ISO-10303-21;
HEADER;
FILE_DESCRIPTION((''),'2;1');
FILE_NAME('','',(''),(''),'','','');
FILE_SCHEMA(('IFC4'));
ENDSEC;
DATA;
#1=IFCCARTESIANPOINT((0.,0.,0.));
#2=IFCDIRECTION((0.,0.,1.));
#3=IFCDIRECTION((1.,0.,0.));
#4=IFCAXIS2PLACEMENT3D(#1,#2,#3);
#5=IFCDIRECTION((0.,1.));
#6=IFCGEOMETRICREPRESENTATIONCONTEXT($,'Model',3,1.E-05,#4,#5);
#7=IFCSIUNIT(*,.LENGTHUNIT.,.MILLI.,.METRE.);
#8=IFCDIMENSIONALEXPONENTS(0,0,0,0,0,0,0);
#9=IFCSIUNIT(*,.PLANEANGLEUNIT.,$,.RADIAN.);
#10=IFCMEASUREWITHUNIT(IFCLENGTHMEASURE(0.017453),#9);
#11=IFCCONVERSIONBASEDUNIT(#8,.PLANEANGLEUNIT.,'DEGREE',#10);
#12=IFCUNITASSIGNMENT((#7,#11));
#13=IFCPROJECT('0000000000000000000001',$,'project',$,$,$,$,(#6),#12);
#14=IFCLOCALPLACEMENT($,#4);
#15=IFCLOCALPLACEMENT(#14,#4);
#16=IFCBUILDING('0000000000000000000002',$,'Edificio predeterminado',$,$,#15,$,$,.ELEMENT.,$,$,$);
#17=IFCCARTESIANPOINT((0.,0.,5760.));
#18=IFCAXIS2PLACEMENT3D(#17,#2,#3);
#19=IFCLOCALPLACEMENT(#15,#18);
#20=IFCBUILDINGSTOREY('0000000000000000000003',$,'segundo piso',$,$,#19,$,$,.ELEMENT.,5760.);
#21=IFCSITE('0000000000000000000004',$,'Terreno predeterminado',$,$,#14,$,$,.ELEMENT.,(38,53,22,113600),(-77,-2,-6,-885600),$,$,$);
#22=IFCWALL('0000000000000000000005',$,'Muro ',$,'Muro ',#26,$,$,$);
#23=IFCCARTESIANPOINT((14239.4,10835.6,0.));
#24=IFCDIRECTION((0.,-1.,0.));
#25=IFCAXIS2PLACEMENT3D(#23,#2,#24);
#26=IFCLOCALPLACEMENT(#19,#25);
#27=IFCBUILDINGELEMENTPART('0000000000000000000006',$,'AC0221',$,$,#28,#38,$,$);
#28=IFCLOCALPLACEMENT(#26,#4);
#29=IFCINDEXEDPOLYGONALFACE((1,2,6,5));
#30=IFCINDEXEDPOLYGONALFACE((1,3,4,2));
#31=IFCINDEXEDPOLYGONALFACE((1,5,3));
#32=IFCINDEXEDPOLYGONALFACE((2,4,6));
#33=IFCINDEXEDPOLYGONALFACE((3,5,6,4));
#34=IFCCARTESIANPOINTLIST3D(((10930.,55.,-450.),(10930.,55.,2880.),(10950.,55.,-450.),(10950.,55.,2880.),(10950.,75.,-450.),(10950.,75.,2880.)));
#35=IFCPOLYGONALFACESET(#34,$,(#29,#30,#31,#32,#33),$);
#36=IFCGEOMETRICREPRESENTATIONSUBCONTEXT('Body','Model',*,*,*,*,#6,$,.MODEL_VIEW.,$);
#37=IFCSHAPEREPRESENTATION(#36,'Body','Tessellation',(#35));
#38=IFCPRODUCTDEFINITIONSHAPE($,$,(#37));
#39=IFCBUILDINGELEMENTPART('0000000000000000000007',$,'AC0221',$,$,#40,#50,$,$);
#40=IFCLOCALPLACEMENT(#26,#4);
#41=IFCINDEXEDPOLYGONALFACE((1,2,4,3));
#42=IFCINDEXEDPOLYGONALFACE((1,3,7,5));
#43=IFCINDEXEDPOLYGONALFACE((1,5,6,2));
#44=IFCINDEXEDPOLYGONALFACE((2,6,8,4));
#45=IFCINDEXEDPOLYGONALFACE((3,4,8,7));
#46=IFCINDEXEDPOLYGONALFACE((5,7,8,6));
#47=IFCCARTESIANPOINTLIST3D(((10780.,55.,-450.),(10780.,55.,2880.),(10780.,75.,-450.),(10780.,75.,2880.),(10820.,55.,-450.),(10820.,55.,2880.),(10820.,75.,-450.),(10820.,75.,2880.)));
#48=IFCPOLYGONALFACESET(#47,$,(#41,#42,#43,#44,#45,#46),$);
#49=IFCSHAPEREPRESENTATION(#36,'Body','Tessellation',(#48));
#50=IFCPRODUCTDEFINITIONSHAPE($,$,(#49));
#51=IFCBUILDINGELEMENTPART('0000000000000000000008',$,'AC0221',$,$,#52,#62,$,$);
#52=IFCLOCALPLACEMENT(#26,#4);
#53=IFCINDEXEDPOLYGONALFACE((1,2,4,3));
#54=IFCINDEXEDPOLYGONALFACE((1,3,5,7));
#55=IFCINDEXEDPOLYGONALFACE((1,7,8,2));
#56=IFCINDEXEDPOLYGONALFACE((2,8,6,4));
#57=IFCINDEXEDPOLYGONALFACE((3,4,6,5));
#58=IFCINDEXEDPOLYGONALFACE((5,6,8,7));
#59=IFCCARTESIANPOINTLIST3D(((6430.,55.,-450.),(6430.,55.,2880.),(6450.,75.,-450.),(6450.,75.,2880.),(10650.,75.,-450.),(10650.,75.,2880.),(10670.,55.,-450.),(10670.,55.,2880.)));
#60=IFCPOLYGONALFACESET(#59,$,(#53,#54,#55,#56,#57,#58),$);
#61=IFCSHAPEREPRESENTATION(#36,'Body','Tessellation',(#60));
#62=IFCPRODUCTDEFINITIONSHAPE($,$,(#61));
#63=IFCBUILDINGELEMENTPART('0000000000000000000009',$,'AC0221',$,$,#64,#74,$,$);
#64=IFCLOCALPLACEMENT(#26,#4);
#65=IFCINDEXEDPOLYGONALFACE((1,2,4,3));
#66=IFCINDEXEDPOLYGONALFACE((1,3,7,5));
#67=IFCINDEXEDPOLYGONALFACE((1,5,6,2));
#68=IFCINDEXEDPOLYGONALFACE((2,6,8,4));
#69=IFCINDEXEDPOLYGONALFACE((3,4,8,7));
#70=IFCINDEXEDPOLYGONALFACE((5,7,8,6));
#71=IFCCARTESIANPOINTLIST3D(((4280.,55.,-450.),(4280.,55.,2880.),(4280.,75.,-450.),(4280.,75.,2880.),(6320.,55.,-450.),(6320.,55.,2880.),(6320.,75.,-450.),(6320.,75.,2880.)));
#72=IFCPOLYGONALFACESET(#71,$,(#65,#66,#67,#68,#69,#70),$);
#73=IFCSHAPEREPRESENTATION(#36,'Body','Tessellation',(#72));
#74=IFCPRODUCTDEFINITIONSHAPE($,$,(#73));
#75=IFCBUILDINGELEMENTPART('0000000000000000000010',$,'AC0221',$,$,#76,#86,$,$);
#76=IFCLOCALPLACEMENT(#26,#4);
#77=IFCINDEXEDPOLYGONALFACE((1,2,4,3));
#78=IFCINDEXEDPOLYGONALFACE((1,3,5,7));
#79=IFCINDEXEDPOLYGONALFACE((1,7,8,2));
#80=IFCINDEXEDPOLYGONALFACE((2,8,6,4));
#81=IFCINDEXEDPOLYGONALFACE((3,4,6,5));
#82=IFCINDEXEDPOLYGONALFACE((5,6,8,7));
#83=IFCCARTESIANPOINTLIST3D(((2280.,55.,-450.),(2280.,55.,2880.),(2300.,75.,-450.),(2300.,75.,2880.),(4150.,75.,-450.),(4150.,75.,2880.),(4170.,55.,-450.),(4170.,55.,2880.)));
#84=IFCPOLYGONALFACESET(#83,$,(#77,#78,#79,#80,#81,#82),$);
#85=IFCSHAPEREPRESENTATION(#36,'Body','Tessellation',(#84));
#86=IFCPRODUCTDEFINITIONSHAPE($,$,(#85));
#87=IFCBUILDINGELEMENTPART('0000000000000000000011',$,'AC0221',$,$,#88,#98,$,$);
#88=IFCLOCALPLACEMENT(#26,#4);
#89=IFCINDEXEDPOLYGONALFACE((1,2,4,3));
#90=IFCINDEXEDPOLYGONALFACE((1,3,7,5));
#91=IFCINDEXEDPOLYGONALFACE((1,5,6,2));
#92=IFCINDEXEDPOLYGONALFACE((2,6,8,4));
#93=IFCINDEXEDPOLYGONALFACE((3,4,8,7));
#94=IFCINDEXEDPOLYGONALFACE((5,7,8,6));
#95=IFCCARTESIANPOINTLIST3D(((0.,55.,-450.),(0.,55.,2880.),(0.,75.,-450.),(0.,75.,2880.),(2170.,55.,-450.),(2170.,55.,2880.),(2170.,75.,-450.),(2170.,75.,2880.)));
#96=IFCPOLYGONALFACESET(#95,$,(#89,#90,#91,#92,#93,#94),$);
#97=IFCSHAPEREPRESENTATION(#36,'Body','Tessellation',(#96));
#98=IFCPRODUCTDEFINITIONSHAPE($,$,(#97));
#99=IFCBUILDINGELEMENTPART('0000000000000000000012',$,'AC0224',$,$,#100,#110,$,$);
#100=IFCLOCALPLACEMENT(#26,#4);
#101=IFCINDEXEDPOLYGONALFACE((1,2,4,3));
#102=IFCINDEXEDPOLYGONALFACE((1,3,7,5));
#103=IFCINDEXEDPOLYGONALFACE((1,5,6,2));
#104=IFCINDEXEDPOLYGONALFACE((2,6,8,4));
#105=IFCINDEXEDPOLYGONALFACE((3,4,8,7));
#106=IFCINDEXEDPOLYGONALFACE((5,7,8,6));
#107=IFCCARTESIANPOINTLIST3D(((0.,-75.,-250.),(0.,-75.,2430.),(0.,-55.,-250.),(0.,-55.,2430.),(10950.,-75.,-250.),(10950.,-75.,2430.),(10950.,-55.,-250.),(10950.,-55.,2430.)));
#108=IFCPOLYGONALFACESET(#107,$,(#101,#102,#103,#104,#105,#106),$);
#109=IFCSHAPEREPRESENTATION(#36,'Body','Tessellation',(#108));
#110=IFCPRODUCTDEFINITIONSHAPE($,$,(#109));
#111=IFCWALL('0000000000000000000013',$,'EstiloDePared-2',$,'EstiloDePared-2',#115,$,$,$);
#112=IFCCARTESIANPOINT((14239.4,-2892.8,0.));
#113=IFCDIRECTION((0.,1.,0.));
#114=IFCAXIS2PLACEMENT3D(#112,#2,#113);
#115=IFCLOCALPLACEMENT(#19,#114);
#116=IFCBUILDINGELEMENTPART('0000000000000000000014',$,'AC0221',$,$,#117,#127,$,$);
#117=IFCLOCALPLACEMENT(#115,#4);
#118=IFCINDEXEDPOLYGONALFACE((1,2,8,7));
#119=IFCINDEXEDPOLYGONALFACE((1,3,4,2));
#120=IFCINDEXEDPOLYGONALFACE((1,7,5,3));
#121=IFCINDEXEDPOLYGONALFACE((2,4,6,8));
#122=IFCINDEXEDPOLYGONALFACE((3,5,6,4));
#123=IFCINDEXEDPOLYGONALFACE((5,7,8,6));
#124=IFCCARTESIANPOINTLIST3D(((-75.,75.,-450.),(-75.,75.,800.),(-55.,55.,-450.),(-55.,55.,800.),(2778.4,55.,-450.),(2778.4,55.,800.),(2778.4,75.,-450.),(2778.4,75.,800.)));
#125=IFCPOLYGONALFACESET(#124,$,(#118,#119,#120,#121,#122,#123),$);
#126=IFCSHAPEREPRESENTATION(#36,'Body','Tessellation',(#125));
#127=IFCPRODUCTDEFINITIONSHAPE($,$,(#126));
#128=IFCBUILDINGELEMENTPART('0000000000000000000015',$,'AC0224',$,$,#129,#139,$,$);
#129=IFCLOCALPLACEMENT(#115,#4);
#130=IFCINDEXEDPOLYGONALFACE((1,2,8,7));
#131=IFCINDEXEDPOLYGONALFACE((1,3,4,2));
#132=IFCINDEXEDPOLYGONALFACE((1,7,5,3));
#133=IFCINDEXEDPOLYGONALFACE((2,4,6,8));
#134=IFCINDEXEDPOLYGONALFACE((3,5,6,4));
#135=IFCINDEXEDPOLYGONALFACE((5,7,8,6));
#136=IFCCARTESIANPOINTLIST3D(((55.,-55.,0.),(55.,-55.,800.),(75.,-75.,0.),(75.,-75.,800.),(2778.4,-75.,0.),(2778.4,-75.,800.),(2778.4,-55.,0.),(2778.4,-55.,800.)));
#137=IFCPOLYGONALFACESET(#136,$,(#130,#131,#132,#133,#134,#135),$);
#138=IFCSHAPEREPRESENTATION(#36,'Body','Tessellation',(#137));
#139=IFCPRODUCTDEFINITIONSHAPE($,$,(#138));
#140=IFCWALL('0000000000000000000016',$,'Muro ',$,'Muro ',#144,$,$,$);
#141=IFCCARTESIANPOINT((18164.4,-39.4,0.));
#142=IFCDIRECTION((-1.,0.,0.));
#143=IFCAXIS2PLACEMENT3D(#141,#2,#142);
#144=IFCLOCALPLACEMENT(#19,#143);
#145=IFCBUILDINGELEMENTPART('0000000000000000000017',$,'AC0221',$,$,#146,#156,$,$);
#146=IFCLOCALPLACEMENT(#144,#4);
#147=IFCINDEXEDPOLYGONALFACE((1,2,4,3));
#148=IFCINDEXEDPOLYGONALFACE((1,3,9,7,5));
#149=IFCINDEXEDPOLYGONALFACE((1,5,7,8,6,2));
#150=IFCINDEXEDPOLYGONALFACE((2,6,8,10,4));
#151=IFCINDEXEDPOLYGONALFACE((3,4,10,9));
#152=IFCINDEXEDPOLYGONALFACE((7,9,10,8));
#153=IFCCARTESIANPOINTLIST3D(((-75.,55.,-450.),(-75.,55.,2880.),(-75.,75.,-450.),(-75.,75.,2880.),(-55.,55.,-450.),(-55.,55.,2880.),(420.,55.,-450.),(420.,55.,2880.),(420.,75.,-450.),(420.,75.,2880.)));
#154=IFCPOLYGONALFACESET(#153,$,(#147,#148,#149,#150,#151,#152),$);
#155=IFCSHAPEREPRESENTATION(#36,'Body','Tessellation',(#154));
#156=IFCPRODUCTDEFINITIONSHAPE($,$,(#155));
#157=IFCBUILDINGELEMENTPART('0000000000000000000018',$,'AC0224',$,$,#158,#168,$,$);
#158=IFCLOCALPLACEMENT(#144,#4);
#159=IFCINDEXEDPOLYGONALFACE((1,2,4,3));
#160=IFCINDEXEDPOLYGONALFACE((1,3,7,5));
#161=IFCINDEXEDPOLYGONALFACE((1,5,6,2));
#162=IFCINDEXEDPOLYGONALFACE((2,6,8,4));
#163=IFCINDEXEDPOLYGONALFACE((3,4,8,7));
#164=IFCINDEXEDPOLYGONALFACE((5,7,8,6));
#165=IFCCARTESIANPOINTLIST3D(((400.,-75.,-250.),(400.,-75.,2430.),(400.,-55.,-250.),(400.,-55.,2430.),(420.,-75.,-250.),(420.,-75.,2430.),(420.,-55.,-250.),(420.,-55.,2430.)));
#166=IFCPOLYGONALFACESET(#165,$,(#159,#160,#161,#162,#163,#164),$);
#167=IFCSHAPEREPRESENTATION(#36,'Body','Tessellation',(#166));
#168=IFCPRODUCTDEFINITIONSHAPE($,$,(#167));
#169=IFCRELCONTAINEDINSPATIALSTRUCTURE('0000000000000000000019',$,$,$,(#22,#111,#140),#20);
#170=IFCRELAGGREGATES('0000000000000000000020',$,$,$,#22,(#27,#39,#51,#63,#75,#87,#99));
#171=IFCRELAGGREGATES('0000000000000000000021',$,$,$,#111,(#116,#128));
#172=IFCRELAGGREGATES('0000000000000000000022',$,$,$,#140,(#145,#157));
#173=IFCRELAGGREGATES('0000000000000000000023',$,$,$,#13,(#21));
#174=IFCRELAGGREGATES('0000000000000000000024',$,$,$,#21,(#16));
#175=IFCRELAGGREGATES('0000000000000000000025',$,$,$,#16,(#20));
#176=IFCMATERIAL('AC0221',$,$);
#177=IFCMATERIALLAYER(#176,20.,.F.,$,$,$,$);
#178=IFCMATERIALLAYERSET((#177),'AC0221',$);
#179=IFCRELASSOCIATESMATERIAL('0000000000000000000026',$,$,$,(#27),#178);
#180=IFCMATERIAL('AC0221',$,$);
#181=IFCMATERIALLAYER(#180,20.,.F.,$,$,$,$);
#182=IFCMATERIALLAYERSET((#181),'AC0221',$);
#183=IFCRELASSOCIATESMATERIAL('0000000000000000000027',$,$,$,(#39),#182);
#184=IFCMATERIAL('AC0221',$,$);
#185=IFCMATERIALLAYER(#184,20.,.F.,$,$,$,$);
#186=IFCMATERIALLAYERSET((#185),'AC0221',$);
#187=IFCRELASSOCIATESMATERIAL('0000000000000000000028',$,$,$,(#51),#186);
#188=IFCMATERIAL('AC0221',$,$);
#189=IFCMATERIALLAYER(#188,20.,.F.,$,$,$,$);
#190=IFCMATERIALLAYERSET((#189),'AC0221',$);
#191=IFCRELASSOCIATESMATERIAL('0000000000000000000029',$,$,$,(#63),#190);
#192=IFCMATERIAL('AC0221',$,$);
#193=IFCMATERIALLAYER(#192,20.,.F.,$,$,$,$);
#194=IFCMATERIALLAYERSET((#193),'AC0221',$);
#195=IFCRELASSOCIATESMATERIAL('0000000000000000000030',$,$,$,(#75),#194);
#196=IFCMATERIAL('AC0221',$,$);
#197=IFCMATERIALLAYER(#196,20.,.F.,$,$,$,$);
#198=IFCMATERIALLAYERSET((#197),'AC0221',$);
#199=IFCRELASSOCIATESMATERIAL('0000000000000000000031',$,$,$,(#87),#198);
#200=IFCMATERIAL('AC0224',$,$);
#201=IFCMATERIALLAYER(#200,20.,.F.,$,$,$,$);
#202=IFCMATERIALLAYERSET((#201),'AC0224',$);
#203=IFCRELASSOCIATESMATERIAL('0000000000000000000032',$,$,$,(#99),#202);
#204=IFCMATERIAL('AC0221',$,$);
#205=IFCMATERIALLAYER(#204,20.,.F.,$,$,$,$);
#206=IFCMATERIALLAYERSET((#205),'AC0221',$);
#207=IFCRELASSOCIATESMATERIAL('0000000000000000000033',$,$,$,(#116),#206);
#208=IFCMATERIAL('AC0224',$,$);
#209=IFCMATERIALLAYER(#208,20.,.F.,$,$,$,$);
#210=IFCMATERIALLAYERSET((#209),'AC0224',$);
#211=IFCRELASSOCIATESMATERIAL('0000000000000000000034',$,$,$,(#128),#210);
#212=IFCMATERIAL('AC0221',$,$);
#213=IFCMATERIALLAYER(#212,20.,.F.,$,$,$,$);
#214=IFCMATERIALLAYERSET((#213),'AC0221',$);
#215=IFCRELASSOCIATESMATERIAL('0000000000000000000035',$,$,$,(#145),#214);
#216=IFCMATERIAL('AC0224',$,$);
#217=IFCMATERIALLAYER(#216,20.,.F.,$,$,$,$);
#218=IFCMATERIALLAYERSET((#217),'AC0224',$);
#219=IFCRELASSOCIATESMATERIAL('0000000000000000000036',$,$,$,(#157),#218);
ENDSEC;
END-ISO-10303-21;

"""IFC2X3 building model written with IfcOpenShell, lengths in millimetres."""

from ifc_helpers import new_model, entity, si_unit, converted_unit, direction, frame, origin_with_axes, place, context, subcontext, project, spatial, polyline, outline, extrude, material, layer, layer_set, layer_usage, element, aggregate, save


model = new_model("IFC2X3")

# Units and contexts
model_context = context("Model", 3, precision=1e-05, world=origin_with_axes(), true_north=direction((0.0, 1.0)))
body_context = subcontext(model_context, "Body", "Model", "MODEL_VIEW")
ifc_project = project(units=[si_unit("LENGTHUNIT", "METRE", prefix="MILLI"), converted_unit("PLANEANGLEUNIT", "DEGREE", entity("IfcLengthMeasure", 0.017453), si_unit("PLANEANGLEUNIT", "RADIAN"), dimensions=[0, 0, 0, 0, 0, 0, 0])], contexts=[model_context])

# Site, building, storey
site_placement = place(None, origin_with_axes())
site = spatial("IfcSite", under=ifc_project, at=site_placement, Name="Terreno predeterminado", CompositionType="ELEMENT", RefLatitude=(38, 53, 22, 113600), RefLongitude=(-77, -2, -6, -885600))
building_placement = place(site_placement, origin_with_axes())
building = spatial("IfcBuilding", under=site, at=building_placement, Name="Edificio predeterminado", CompositionType="ELEMENT")
storey_placement = place(building_placement, frame((0.0, 0.0, 5760.0), z_axis=(0.0, 0.0, 1.0), x_axis=(1.0, 0.0, 0.0)))
storey = spatial("IfcBuildingStorey", under=building, at=storey_placement, Name="segundo piso", CompositionType="ELEMENT", Elevation=5760.0)

# Walls, building element parts
wall_1_placement = place(storey_placement, frame((14239.4, 10835.6, 0.0), z_axis=(0.0, 0.0, 1.0), x_axis=(0.0, -1.0, 0.0)))
wall_1 = element("IfcWall", 1, at=wall_1_placement, inside=storey, Name="Muro ", ObjectType="Muro ")
ifc_material_1 = material(Name="AC0221")
ifc_layer_1 = layer(ifc_material_1, 20.0, ventilated=False)
ifc_layer_set_1 = layer_set([ifc_layer_1], Name="AC0221")
ifc_layer_usage_1 = layer_usage(ifc_layer_set_1, "AXIS2", "NEGATIVE", -75.0)
building_element_part_1_placement = place(wall_1_placement, origin_with_axes())
building_element_part_1 = element("IfcBuildingElementPart", 2, at=building_element_part_1_placement, material=ifc_layer_usage_1, Name="AC0221", context=body_context, shape_type="SweptSolid", body=[
    extrude(outline(polyline([(10950.0, 75.0), (10950.0, 55.0), (10930.0, 55.0), (10950.0, 75.0)])), frame((0.0, 0.0, -450.0), z_axis=(0.0, 0.0, 1.0), x_axis=(1.0, 0.0, 0.0)), (0.0, 0.0, 1.0), 3330.0),
])
ifc_material_2 = material(Name="AC0221")
ifc_layer_2 = layer(ifc_material_2, 20.0, ventilated=False)
ifc_layer_set_2 = layer_set([ifc_layer_2], Name="AC0221")
ifc_layer_usage_2 = layer_usage(ifc_layer_set_2, "AXIS2", "NEGATIVE", -75.0)
building_element_part_2_placement = place(wall_1_placement, origin_with_axes())
building_element_part_2 = element("IfcBuildingElementPart", 3, at=building_element_part_2_placement, material=ifc_layer_usage_2, Name="AC0221", context=body_context, shape_type="SweptSolid", body=[
    extrude(outline(polyline([(10820.0, 75.0), (10820.0, 55.0), (10780.0, 55.0), (10780.0, 75.0), (10820.0, 75.0)])), frame((0.0, 0.0, -450.0), z_axis=(0.0, 0.0, 1.0), x_axis=(1.0, 0.0, 0.0)), (0.0, 0.0, 1.0), 3330.0),
])
ifc_material_3 = material(Name="AC0221")
ifc_layer_3 = layer(ifc_material_3, 20.0, ventilated=False)
ifc_layer_set_3 = layer_set([ifc_layer_3], Name="AC0221")
ifc_layer_usage_3 = layer_usage(ifc_layer_set_3, "AXIS2", "NEGATIVE", -75.0)
building_element_part_3_placement = place(wall_1_placement, origin_with_axes())
building_element_part_3 = element("IfcBuildingElementPart", 4, at=building_element_part_3_placement, material=ifc_layer_usage_3, Name="AC0221", context=body_context, shape_type="SweptSolid", body=[
    extrude(outline(polyline([(10650.0, 75.0), (10670.0, 55.0), (6430.0, 55.0), (6450.0, 75.0), (10650.0, 75.0)])), frame((0.0, 0.0, -450.0), z_axis=(0.0, 0.0, 1.0), x_axis=(1.0, 0.0, 0.0)), (0.0, 0.0, 1.0), 3330.0),
])
ifc_material_4 = material(Name="AC0221")
ifc_layer_4 = layer(ifc_material_4, 20.0, ventilated=False)
ifc_layer_set_4 = layer_set([ifc_layer_4], Name="AC0221")
ifc_layer_usage_4 = layer_usage(ifc_layer_set_4, "AXIS2", "NEGATIVE", -75.0)
building_element_part_4_placement = place(wall_1_placement, origin_with_axes())
building_element_part_4 = element("IfcBuildingElementPart", 5, at=building_element_part_4_placement, material=ifc_layer_usage_4, Name="AC0221", context=body_context, shape_type="SweptSolid", body=[
    extrude(outline(polyline([(4280.0, 75.0), (6320.0, 75.0), (6320.0, 55.0), (4280.0, 55.0), (4280.0, 75.0)])), frame((0.0, 0.0, -450.0), z_axis=(0.0, 0.0, 1.0), x_axis=(1.0, 0.0, 0.0)), (0.0, 0.0, 1.0), 3330.0),
])
ifc_material_5 = material(Name="AC0221")
ifc_layer_5 = layer(ifc_material_5, 20.0, ventilated=False)
ifc_layer_set_5 = layer_set([ifc_layer_5], Name="AC0221")
ifc_layer_usage_5 = layer_usage(ifc_layer_set_5, "AXIS2", "NEGATIVE", -75.0)
building_element_part_5_placement = place(wall_1_placement, origin_with_axes())
building_element_part_5 = element("IfcBuildingElementPart", 6, at=building_element_part_5_placement, material=ifc_layer_usage_5, Name="AC0221", context=body_context, shape_type="SweptSolid", body=[
    extrude(outline(polyline([(4150.0, 75.0), (4170.0, 55.0), (2280.0, 55.0), (2300.0, 75.0), (4150.0, 75.0)])), frame((0.0, 0.0, -450.0), z_axis=(0.0, 0.0, 1.0), x_axis=(1.0, 0.0, 0.0)), (0.0, 0.0, 1.0), 3330.0),
])
ifc_material_6 = material(Name="AC0221")
ifc_layer_6 = layer(ifc_material_6, 20.0, ventilated=False)
ifc_layer_set_6 = layer_set([ifc_layer_6], Name="AC0221")
ifc_layer_usage_6 = layer_usage(ifc_layer_set_6, "AXIS2", "NEGATIVE", -75.0)
building_element_part_6_placement = place(wall_1_placement, origin_with_axes())
building_element_part_6 = element("IfcBuildingElementPart", 7, at=building_element_part_6_placement, material=ifc_layer_usage_6, Name="AC0221", context=body_context, shape_type="SweptSolid", body=[
    extrude(outline(polyline([(2170.0, 75.0), (2170.0, 55.0), (0.0, 55.0), (0.0, 75.0), (2170.0, 75.0)])), frame((0.0, 0.0, -450.0), z_axis=(0.0, 0.0, 1.0), x_axis=(1.0, 0.0, 0.0)), (0.0, 0.0, 1.0), 3330.0),
])
ifc_material_7 = material(Name="AC0224")
ifc_layer_7 = layer(ifc_material_7, 20.0, ventilated=False)
ifc_layer_set_7 = layer_set([ifc_layer_7], Name="AC0224")
ifc_layer_usage_7 = layer_usage(ifc_layer_set_7, "AXIS2", "NEGATIVE", 55.0)
building_element_part_7_placement = place(wall_1_placement, origin_with_axes())
building_element_part_7 = element("IfcBuildingElementPart", 8, at=building_element_part_7_placement, material=ifc_layer_usage_7, Name="AC0224", context=body_context, shape_type="SweptSolid", body=[
    extrude(outline(polyline([(10950.0, -55.0), (10950.0, -75.0), (0.0, -75.0), (0.0, -55.0), (10950.0, -55.0)])), frame((0.0, 0.0, -250.0), z_axis=(0.0, 0.0, 1.0), x_axis=(1.0, 0.0, 0.0)), (0.0, 0.0, 1.0), 2680.0),
])
aggregate(wall_1, [building_element_part_1, building_element_part_2, building_element_part_3, building_element_part_4, building_element_part_5, building_element_part_6, building_element_part_7])
wall_2_placement = place(storey_placement, frame((14239.4, -2892.8, 0.0), z_axis=(0.0, 0.0, 1.0), x_axis=(0.0, 1.0, 0.0)))
wall_2 = element("IfcWall", 9, at=wall_2_placement, inside=storey, Name="EstiloDePared-2", ObjectType="EstiloDePared-2")
ifc_material_8 = material(Name="AC0221")
ifc_layer_8 = layer(ifc_material_8, 20.0, ventilated=False)
ifc_layer_set_8 = layer_set([ifc_layer_8], Name="AC0221")
ifc_layer_usage_8 = layer_usage(ifc_layer_set_8, "AXIS2", "NEGATIVE", -75.0)
building_element_part_8_placement = place(wall_2_placement, origin_with_axes())
building_element_part_8 = element("IfcBuildingElementPart", 10, at=building_element_part_8_placement, material=ifc_layer_usage_8, Name="AC0221", context=body_context, shape_type="SweptSolid", body=[
    extrude(outline(polyline([(2778.4, 75.0), (2778.4, 55.0), (-55.0, 55.0), (-75.0, 75.0), (2778.4, 75.0)])), frame((0.0, 0.0, -450.0), z_axis=(0.0, 0.0, 1.0), x_axis=(1.0, 0.0, 0.0)), (0.0, 0.0, 1.0), 1250.0),
])
ifc_material_9 = material(Name="AC0224")
ifc_layer_9 = layer(ifc_material_9, 20.0, ventilated=False)
ifc_layer_set_9 = layer_set([ifc_layer_9], Name="AC0224")
ifc_layer_usage_9 = layer_usage(ifc_layer_set_9, "AXIS2", "NEGATIVE", 55.0)
building_element_part_9_placement = place(wall_2_placement, origin_with_axes())
building_element_part_9 = element("IfcBuildingElementPart", 11, at=building_element_part_9_placement, material=ifc_layer_usage_9, Name="AC0224", context=body_context, shape_type="SweptSolid", body=[
    extrude(outline(polyline([(2778.4, -55.0), (2778.4, -75.0), (75.0, -75.0), (55.0, -55.0), (2778.4, -55.0)])), origin_with_axes(), (0.0, 0.0, 1.0), 800.0),
])
aggregate(wall_2, [building_element_part_8, building_element_part_9])
wall_3_placement = place(storey_placement, frame((18164.4, -39.4, 0.0), z_axis=(0.0, 0.0, 1.0), x_axis=(-1.0, 0.0, 0.0)))
wall_3 = element("IfcWall", 12, at=wall_3_placement, inside=storey, Name="Muro ", ObjectType="Muro ")
ifc_material_10 = material(Name="AC0221")
ifc_layer_10 = layer(ifc_material_10, 20.0, ventilated=False)
ifc_layer_set_10 = layer_set([ifc_layer_10], Name="AC0221")
ifc_layer_usage_10 = layer_usage(ifc_layer_set_10, "AXIS2", "NEGATIVE", -75.0)
building_element_part_10_placement = place(wall_3_placement, origin_with_axes())
building_element_part_10 = element("IfcBuildingElementPart", 13, at=building_element_part_10_placement, material=ifc_layer_usage_10, Name="AC0221", context=body_context, shape_type="SweptSolid", body=[
    extrude(outline(polyline([(420.0, 75.0), (420.0, 55.0), (-55.0, 55.0), (-75.0, 55.0), (-75.0, 75.0), (420.0, 75.0)])), frame((0.0, 0.0, -450.0), z_axis=(0.0, 0.0, 1.0), x_axis=(1.0, 0.0, 0.0)), (0.0, 0.0, 1.0), 3330.0),
])
ifc_material_11 = material(Name="AC0224")
ifc_layer_11 = layer(ifc_material_11, 20.0, ventilated=False)
ifc_layer_set_11 = layer_set([ifc_layer_11], Name="AC0224")
ifc_layer_usage_11 = layer_usage(ifc_layer_set_11, "AXIS2", "NEGATIVE", 55.0)
building_element_part_11_placement = place(wall_3_placement, origin_with_axes())
building_element_part_11 = element("IfcBuildingElementPart", 14, at=building_element_part_11_placement, material=ifc_layer_usage_11, Name="AC0224", context=body_context, shape_type="SweptSolid", body=[
    extrude(outline(polyline([(420.0, -55.0), (420.0, -75.0), (400.0, -75.0), (400.0, -55.0), (420.0, -55.0)])), frame((0.0, 0.0, -250.0), z_axis=(0.0, 0.0, 1.0), x_axis=(1.0, 0.0, 0.0)), (0.0, 0.0, 1.0), 2680.0),
])
aggregate(wall_3, [building_element_part_10, building_element_part_11])

save(model, "model.ifc")
